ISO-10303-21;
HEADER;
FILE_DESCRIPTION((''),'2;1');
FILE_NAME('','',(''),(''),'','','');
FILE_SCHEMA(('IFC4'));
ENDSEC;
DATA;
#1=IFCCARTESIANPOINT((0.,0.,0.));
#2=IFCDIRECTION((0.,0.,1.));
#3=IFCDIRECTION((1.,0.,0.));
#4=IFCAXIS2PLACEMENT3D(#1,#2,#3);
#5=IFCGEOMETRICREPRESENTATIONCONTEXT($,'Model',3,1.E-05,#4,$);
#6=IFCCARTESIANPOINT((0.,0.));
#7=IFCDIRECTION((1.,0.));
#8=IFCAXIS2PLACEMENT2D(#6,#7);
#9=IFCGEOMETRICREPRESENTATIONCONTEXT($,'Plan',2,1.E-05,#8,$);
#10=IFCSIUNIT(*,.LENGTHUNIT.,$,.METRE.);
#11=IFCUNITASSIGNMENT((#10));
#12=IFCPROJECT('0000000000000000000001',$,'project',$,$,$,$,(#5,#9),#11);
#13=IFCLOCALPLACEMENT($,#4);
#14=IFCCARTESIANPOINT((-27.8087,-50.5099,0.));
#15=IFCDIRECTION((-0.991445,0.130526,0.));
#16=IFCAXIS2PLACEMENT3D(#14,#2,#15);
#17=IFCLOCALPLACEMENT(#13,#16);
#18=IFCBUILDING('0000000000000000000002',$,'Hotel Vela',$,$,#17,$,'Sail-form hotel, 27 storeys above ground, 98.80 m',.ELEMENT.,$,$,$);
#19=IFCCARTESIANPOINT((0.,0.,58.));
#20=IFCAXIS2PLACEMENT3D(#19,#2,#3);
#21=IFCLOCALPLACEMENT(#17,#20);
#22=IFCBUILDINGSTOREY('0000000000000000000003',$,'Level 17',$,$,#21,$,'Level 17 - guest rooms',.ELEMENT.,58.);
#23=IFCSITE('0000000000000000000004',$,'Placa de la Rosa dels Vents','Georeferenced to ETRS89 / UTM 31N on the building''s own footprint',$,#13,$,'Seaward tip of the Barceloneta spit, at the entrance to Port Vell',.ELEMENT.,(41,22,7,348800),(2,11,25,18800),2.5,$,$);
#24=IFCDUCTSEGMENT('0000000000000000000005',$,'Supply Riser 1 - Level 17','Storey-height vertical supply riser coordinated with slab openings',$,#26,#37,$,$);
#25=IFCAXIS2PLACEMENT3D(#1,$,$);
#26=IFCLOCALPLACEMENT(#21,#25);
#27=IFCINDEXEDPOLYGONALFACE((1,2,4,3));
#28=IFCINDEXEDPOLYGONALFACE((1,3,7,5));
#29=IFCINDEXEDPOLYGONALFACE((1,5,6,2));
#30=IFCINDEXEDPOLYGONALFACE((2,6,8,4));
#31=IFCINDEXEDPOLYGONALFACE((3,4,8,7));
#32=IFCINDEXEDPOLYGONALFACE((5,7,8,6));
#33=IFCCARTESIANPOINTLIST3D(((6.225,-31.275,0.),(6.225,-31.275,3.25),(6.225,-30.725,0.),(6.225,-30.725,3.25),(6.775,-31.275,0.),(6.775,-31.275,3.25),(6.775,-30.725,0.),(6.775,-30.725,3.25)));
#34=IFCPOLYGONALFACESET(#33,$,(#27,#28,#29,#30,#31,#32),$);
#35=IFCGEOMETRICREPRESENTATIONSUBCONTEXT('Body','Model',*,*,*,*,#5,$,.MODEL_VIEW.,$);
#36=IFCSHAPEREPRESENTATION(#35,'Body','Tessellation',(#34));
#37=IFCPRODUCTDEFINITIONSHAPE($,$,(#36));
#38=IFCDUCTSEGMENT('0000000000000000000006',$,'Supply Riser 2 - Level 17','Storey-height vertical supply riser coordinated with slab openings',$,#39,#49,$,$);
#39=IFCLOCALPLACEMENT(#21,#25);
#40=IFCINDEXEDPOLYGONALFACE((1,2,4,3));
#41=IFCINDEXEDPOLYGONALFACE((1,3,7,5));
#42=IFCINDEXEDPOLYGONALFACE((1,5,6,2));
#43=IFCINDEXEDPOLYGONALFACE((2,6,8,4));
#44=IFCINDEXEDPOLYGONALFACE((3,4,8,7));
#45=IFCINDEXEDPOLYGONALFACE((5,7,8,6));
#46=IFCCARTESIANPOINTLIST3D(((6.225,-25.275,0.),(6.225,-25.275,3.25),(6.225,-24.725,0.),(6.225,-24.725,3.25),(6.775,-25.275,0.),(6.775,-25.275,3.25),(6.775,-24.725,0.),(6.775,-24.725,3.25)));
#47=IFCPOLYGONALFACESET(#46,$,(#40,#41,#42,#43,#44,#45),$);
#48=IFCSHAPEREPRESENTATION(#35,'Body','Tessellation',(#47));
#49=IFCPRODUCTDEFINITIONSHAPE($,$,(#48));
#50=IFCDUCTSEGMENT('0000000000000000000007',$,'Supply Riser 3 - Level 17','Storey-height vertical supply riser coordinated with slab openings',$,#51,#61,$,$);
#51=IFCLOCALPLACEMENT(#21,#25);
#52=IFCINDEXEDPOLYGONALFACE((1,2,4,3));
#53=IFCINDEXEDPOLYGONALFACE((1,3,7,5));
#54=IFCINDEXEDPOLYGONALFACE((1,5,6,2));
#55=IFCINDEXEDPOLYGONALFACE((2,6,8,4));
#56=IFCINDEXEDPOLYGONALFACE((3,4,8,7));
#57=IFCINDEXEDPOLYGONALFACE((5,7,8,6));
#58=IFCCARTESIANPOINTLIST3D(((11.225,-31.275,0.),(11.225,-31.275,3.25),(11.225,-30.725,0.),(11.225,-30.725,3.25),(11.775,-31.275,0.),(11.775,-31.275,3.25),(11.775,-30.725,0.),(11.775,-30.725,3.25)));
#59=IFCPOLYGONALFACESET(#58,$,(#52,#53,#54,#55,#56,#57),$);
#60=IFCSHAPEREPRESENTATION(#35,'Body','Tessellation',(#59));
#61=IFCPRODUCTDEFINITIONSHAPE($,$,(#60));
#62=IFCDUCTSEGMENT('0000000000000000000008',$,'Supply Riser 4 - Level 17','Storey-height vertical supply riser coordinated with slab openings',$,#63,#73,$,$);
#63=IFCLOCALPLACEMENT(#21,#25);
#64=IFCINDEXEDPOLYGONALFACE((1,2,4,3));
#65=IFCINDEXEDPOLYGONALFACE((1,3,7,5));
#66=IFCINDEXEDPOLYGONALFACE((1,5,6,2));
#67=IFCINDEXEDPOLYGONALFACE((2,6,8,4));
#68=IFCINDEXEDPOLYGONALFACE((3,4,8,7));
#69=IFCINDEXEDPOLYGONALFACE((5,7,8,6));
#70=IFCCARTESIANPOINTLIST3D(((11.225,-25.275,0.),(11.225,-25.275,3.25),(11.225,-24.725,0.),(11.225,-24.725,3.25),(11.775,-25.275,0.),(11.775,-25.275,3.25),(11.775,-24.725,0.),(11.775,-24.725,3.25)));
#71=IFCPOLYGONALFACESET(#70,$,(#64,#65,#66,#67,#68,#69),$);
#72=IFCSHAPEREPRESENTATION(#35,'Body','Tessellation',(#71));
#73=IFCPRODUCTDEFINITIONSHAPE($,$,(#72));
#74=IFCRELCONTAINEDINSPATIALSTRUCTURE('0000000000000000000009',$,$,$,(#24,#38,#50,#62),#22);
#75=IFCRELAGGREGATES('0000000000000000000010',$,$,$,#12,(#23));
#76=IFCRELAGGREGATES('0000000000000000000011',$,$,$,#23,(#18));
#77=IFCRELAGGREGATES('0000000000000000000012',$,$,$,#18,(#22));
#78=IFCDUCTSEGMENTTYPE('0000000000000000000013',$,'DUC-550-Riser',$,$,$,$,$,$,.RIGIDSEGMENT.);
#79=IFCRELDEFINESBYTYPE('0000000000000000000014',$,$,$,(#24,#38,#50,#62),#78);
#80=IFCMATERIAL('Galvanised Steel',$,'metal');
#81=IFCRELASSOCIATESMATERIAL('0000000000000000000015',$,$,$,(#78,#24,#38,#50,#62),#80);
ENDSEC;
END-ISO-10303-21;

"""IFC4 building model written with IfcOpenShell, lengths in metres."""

from ifc_helpers import new_model, si_unit, frame, origin_with_axes, origin_2d_with_axis, place, context, subcontext, project, spatial, line, indexed_curve, outline, extrude, material, type_object, element, save


model = new_model("IFC4")

# Units and contexts
model_context = context("Model", 3, precision=1e-05, world=origin_with_axes())
plan_context = context("Plan", 2, precision=1e-05, world=origin_2d_with_axis())
body_context = subcontext(model_context, "Body", "Model", "MODEL_VIEW")
ifc_project = project(units=[si_unit("LENGTHUNIT", "METRE")], contexts=[model_context, plan_context])

# Site, building, storey
site_placement = place(None, origin_with_axes())
site = spatial("IfcSite", under=ifc_project, at=site_placement, Name="Placa de la Rosa dels Vents", Description="Georeferenced to ETRS89 / UTM 31N on the building's own footprint", LongName="Seaward tip of the Barceloneta spit, at the entrance to Port Vell", CompositionType="ELEMENT", RefLatitude=(41, 22, 7, 348800), RefLongitude=(2, 11, 25, 18800), RefElevation=2.5)
building_placement = place(site_placement, frame((-27.8087, -50.5099, 0.0), z_axis=(0.0, 0.0, 1.0), x_axis=(-0.991445, 0.130526, 0.0)))
building = spatial("IfcBuilding", under=site, at=building_placement, Name="Hotel Vela", LongName="Sail-form hotel, 27 storeys above ground, 98.80 m", CompositionType="ELEMENT")
storey_placement = place(building_placement, frame((0.0, 0.0, 58.0), z_axis=(0.0, 0.0, 1.0), x_axis=(1.0, 0.0, 0.0)))
storey = spatial("IfcBuildingStorey", under=building, at=storey_placement, Name="Level 17", LongName="Level 17 - guest rooms", CompositionType="ELEMENT", Elevation=58.0)

# Duct segments
ifc_material = material(Name="Galvanised Steel", Category="metal")
duct_segment_type = type_object("IfcDuctSegmentType", Name="DUC-550-Riser", PredefinedType="RIGIDSEGMENT", material=ifc_material)
for number, where, z_axis, x_axis, name in (
    (1, (6.225, -31.275, 0.0), (0.0, 0.0, 1.0), (1.0, 0.0, 0.0), "Supply Riser 1 - Level 17"),
    (2, (6.225, -25.275, 0.0), (0.0, 0.0, 1.0), (1.0, 0.0, 0.0), "Supply Riser 2 - Level 17"),
    (3, (11.225, -31.275, 0.0), (0.0, 0.0, 1.0), (1.0, 0.0, 0.0), "Supply Riser 3 - Level 17"),
    (4, (11.225, -25.275, 0.0), (0.0, 0.0, 1.0), (1.0, 0.0, 0.0), "Supply Riser 4 - Level 17"),
):
    element("IfcDuctSegment", number, at=place(storey_placement, frame(where, z_axis=z_axis, x_axis=x_axis)), inside=storey, type_object=duct_segment_type, material=ifc_material, Name=name, Description="Storey-height vertical supply riser coordinated with slab openings", context=body_context, shape_type="SweptSolid", body=[
        extrude(outline(indexed_curve([(0.0, 0.0), (0.55, 0.0), (0.55, 0.55), (0.0, 0.55)], segments=[line(1, 2, 3, 4, 1)])), origin_with_axes(), (0.0, 0.0, 1.0), 3.25),
    ])

save(model, "model.ifc")
